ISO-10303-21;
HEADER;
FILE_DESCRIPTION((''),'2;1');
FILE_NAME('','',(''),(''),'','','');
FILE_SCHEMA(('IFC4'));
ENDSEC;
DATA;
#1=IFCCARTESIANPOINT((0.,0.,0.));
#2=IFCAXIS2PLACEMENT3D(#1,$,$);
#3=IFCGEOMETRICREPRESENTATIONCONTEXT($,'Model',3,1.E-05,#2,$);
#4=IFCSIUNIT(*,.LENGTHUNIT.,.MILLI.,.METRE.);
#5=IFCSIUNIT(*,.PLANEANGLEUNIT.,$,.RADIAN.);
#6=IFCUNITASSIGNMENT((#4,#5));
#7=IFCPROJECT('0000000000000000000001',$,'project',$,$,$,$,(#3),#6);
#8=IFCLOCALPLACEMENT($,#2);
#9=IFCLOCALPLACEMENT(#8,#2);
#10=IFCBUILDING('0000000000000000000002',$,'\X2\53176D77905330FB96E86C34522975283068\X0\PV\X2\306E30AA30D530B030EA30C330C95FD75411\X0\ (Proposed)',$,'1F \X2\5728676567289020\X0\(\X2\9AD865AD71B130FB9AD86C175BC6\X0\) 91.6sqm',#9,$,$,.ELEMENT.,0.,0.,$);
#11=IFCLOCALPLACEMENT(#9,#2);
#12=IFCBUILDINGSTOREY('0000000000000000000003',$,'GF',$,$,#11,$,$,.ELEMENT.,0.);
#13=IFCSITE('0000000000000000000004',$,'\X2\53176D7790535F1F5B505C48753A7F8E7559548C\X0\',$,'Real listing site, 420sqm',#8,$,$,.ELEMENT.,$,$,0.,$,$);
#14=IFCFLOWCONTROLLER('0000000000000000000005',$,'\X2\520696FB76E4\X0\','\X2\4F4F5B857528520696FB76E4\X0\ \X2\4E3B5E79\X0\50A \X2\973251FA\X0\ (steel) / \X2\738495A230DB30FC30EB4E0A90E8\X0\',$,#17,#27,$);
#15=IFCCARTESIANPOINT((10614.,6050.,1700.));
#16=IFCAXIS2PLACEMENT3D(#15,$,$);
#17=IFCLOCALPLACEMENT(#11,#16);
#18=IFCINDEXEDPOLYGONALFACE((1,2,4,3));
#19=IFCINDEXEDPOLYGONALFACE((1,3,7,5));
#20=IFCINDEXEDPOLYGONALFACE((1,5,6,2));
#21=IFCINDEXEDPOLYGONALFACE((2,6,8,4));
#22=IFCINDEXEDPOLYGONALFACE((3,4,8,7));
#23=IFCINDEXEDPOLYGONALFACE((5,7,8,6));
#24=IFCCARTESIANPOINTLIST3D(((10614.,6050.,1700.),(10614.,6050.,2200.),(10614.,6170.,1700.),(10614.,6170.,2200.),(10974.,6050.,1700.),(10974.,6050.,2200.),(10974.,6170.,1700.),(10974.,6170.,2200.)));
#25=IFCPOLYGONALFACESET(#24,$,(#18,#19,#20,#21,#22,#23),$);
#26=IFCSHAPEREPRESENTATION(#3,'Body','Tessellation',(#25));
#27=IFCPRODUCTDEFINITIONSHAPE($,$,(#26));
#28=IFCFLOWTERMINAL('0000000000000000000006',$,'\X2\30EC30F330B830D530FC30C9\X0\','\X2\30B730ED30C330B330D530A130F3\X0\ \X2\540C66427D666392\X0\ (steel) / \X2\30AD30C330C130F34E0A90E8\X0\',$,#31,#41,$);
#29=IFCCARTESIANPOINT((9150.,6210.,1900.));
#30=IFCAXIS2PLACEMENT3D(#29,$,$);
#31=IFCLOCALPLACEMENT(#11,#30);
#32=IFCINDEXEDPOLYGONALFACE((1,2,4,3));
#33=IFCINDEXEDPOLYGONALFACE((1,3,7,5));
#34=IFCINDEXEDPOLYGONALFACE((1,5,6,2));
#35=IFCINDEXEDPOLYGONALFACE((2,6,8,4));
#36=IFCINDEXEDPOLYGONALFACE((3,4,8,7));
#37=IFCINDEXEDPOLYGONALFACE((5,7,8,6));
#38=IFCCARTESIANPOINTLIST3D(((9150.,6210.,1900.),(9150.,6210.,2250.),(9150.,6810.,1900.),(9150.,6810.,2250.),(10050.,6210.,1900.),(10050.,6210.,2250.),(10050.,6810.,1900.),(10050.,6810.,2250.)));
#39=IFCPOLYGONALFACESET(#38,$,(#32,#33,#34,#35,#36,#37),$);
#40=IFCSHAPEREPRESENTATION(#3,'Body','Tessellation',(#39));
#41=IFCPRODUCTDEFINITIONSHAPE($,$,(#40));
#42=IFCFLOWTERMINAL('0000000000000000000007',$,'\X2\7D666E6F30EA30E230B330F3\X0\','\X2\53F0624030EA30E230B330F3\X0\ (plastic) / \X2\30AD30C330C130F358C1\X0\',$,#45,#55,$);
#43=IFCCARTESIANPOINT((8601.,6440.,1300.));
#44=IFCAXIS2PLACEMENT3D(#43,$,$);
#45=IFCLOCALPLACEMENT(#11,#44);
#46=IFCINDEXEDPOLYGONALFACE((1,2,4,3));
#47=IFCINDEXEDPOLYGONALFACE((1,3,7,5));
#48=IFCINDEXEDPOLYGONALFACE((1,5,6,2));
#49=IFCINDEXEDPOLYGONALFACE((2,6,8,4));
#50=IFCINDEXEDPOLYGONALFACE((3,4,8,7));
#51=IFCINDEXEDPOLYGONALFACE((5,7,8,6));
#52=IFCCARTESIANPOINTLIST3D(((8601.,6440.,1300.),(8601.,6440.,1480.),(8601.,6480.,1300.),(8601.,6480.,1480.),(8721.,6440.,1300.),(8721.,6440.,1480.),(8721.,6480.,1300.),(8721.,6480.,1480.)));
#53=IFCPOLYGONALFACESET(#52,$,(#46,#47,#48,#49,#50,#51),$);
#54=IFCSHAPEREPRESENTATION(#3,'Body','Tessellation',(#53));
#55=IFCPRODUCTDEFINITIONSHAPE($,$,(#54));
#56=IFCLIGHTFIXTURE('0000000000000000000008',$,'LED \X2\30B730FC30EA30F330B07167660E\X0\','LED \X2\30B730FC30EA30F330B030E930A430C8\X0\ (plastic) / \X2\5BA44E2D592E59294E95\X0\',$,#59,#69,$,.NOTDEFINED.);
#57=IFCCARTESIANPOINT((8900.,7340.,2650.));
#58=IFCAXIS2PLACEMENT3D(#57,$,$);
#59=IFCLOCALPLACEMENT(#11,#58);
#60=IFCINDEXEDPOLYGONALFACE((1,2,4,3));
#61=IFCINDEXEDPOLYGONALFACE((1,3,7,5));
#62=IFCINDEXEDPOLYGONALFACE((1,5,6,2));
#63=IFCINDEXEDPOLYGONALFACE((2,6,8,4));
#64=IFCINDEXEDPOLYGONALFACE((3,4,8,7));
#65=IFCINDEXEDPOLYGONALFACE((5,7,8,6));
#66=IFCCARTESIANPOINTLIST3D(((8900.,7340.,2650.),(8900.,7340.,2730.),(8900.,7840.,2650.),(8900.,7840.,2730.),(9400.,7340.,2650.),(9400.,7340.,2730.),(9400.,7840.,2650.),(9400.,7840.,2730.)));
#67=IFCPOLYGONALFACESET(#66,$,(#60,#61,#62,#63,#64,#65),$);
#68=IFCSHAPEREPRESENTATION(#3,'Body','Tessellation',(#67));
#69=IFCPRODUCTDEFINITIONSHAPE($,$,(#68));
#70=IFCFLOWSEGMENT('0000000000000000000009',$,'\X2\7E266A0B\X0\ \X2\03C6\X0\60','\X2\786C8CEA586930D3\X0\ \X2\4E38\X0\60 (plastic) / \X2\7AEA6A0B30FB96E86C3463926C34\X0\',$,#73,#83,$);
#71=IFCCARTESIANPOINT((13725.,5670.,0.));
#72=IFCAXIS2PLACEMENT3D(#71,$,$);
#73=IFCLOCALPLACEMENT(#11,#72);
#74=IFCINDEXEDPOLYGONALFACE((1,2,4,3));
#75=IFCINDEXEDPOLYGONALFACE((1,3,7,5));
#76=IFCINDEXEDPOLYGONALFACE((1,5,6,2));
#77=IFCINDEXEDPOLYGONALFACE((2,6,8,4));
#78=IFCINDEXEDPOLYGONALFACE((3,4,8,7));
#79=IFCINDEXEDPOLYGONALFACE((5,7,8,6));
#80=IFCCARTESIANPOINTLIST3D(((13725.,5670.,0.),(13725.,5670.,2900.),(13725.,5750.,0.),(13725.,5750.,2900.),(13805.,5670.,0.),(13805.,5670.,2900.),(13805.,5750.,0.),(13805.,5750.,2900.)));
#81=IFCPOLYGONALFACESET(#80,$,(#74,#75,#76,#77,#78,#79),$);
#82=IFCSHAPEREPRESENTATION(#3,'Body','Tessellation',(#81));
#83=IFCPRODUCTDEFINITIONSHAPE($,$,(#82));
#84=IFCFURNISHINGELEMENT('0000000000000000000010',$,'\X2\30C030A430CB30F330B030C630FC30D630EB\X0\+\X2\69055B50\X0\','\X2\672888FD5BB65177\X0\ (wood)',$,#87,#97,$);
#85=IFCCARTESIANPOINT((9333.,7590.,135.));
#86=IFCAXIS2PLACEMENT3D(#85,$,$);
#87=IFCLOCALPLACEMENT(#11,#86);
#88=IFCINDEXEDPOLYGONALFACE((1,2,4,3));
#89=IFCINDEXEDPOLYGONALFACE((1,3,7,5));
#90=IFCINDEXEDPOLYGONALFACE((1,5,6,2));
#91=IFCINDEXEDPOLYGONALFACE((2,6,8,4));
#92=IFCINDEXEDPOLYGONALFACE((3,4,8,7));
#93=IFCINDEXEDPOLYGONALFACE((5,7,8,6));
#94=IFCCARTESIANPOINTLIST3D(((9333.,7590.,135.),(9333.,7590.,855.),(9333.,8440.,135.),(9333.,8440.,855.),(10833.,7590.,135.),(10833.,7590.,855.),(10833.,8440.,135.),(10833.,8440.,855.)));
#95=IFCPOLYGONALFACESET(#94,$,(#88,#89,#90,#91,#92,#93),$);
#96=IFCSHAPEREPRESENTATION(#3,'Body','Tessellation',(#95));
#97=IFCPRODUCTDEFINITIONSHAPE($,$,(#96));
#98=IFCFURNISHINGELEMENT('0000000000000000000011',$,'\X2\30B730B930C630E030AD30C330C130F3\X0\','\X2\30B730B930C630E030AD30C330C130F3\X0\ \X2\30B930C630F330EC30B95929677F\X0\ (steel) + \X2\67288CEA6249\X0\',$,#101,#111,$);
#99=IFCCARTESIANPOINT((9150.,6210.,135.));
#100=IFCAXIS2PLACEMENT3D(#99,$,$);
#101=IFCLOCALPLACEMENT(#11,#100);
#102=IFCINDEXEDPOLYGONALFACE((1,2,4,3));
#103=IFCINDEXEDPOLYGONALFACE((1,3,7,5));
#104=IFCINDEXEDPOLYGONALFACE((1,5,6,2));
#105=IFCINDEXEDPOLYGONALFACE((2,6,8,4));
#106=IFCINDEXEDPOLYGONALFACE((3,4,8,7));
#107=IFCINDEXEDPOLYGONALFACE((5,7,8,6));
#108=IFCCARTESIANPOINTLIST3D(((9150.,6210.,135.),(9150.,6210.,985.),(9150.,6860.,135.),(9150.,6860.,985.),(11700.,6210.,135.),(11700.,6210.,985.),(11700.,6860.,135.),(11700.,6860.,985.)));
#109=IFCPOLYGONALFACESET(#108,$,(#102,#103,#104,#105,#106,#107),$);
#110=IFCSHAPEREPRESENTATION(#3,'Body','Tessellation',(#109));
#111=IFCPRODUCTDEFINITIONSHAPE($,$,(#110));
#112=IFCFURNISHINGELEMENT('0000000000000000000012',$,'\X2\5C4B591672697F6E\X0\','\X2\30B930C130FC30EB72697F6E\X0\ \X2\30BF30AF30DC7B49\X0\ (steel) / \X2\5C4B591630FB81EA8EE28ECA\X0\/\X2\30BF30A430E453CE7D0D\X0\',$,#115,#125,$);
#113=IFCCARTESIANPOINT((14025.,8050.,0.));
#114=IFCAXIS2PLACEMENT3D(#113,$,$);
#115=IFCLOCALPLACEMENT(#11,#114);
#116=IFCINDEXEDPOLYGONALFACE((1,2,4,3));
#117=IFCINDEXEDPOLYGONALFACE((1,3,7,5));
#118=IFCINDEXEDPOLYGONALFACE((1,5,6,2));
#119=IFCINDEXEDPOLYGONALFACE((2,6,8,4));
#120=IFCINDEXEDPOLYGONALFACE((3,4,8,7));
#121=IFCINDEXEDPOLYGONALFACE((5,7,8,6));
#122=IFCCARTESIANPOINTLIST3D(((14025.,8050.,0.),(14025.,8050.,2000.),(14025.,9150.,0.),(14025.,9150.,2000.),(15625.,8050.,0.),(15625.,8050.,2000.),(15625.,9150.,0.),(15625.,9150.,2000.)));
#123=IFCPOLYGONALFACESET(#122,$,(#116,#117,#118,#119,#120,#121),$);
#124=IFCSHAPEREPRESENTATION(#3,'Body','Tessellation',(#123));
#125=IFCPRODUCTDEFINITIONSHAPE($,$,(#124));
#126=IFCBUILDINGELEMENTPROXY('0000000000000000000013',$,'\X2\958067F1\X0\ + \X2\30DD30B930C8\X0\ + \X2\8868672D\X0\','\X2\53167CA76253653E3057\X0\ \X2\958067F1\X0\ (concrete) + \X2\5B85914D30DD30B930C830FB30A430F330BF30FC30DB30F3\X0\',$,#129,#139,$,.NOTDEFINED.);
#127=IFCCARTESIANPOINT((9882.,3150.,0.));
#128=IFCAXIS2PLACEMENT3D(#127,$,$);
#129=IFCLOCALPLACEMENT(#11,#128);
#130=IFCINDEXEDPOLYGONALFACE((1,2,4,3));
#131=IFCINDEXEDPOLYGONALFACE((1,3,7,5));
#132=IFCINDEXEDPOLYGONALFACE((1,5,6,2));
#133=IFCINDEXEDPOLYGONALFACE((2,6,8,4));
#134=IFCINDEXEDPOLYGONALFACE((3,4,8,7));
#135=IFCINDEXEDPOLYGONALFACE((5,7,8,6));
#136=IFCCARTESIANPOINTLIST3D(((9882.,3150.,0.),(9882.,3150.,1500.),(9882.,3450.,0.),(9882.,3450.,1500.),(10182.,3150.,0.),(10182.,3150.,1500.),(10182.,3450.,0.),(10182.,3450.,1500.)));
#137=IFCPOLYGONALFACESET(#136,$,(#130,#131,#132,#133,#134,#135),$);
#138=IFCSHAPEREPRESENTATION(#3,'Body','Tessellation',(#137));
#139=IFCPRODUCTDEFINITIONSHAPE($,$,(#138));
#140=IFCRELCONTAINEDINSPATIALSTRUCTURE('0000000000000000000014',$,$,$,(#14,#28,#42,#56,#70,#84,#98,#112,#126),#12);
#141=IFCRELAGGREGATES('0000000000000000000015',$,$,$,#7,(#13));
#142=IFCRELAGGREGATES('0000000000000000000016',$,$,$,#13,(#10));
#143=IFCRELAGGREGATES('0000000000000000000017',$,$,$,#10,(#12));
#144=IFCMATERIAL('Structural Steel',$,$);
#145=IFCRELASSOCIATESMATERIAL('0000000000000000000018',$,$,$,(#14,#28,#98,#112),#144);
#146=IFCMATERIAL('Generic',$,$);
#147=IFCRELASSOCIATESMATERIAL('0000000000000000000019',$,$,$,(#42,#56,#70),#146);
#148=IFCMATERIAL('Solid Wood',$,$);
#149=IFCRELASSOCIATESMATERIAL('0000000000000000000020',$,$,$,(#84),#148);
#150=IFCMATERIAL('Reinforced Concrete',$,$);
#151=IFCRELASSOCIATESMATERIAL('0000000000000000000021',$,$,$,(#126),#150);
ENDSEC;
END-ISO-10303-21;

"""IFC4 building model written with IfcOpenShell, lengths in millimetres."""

from ifc_helpers import new_model, si_unit, frame, frame_2d, origin, place, context, project, spatial, rectangle, extrude, material, element, save


model = new_model("IFC4")

# Units and contexts
model_context = context("Model", 3, precision=1e-05, world=origin())
ifc_project = project(units=[si_unit("LENGTHUNIT", "METRE", prefix="MILLI"), si_unit("PLANEANGLEUNIT", "RADIAN")], contexts=[model_context])

# Site, building, storey
site_placement = place(None, origin())
site = spatial("IfcSite", under=ifc_project, at=site_placement, Name="北海道弟子屈町美留和", ObjectType="Real listing site, 420sqm", CompositionType="ELEMENT", RefElevation=0.0)
building_placement = place(site_placement, origin())
building = spatial("IfcBuilding", under=site, at=building_placement, Name="北海道・雨水利用とPVのオフグリッド志向 (Proposed)", ObjectType="1F 在来木造(高断熱・高気密) 91.6sqm", CompositionType="ELEMENT", ElevationOfRefHeight=0.0, ElevationOfTerrain=0.0)
storey_placement = place(building_placement, origin())
storey = spatial("IfcBuildingStorey", under=building, at=storey_placement, Name="GF", CompositionType="ELEMENT", Elevation=0.0)

# Shared definitions
ifc_material_1 = material(Name="Solid Wood")

# Shared definitions
ifc_material_2 = material(Name="Structural Steel")

# Shared definitions
ifc_material_3 = material(Name="Reinforced Concrete")

# Flow controller
flow_controller_placement = place(storey_placement, frame((10614.0, 6050.0, 1700.0)))
element("IfcFlowController", 1, at=flow_controller_placement, inside=storey, material=ifc_material_2, Name="分電盤", Description="住宅用分電盤 主幹50A 露出 (steel) / 玄関ホール上部", context=model_context, shape_type="SweptSolid", body=[
    extrude(rectangle(XDim=360.0, YDim=120.0, at=frame_2d((180.0, 60.0))), frame((10614.0, 6050.0, 1700.0)), (0.0, 0.0, 1.0), 500.0),
])

# Flow terminals
flow_terminal_1_placement = place(storey_placement, frame((9150.0, 6210.0, 1900.0)))
element("IfcFlowTerminal", 2, at=flow_terminal_1_placement, inside=storey, material=ifc_material_2, Name="レンジフード", Description="シロッコファン 同時給排 (steel) / キッチン上部", context=model_context, shape_type="SweptSolid", body=[
    extrude(rectangle(XDim=900.0, YDim=600.0, at=frame_2d((450.0, 300.0))), frame((9150.0, 6210.0, 1900.0)), (0.0, 0.0, 1.0), 350.0),
])
ifc_material_4 = material(Name="Generic")
flow_terminal_2_placement = place(storey_placement, frame((8601.0, 6440.0, 1300.0)))
element("IfcFlowTerminal", 3, at=flow_terminal_2_placement, inside=storey, material=ifc_material_4, Name="給湯リモコン", Description="台所リモコン (plastic) / キッチン壁", context=model_context, shape_type="SweptSolid", body=[
    extrude(rectangle(XDim=120.0, YDim=40.0, at=frame_2d((60.0, 20.0))), frame((8601.0, 6440.0, 1300.0)), (0.0, 0.0, 1.0), 180.0),
])

# Light fixture
light_fixture_placement = place(storey_placement, frame((8900.0, 7340.0, 2650.0)))
element("IfcLightFixture", 4, at=light_fixture_placement, inside=storey, material=ifc_material_4, Name="LED シーリング照明", Description="LED シーリングライト (plastic) / 室中央天井", PredefinedType="NOTDEFINED", context=model_context, shape_type="SweptSolid", body=[
    extrude(rectangle(XDim=500.0, YDim=500.0, at=frame_2d((250.0, 250.0))), frame((8900.0, 7340.0, 2650.0)), (0.0, 0.0, 1.0), 80.0),
])

# Flow segment
flow_segment_placement = place(storey_placement, frame((13725.0, 5670.0, 0.0)))
element("IfcFlowSegment", 5, at=flow_segment_placement, inside=storey, material=ifc_material_4, Name="縦樋 φ60", Description="硬質塩ビ 丸60 (plastic) / 竪樋・雨水排水", context=model_context, shape_type="SweptSolid", body=[
    extrude(rectangle(XDim=80.0, YDim=80.0, at=frame_2d((40.0, 40.0))), frame((13725.0, 5670.0, 0.0)), (0.0, 0.0, 1.0), 2900.0),
])

# Furnishing elements
furnishing_1_placement = place(storey_placement, frame((9333.0, 7590.0, 135.0)))
element("IfcFurnishingElement", 6, at=furnishing_1_placement, inside=storey, material=ifc_material_1, Name="ダイニングテーブル+椅子", Description="木製家具 (wood)", context=model_context, shape_type="SweptSolid", body=[
    extrude(rectangle(XDim=1500.0, YDim=850.0, at=frame_2d((750.0, 425.0))), frame((9333.0, 7590.0, 135.0)), (0.0, 0.0, 1.0), 720.0),
])
furnishing_2_placement = place(storey_placement, frame((9150.0, 6210.0, 135.0)))
element("IfcFurnishingElement", 7, at=furnishing_2_placement, inside=storey, material=ifc_material_2, Name="システムキッチン", Description="システムキッチン ステンレス天板 (steel) + 木質扉", context=model_context, shape_type="SweptSolid", body=[
    extrude(rectangle(XDim=2550.0, YDim=650.0, at=frame_2d((1275.0, 325.0))), frame((9150.0, 6210.0, 135.0)), (0.0, 0.0, 1.0), 850.0),
])
furnishing_3_placement = place(storey_placement, frame((14025.0, 8050.0, 0.0)))
element("IfcFurnishingElement", 8, at=furnishing_3_placement, inside=storey, material=ifc_material_2, Name="屋外物置", Description="スチール物置 タクボ等 (steel) / 屋外・自転車/タイヤ収納", context=model_context, shape_type="SweptSolid", body=[
    extrude(rectangle(XDim=1600.0, YDim=1100.0, at=frame_2d((800.0, 550.0))), frame((14025.0, 8050.0, 0.0)), (0.0, 0.0, 1.0), 2000.0),
])

# Building element proxy
proxy_placement = place(storey_placement, frame((9882.0, 3150.0, 0.0)))
element("IfcBuildingElementProxy", 9, at=proxy_placement, inside=storey, material=ifc_material_3, Name="門柱 + ポスト + 表札", Description="化粧打放し 門柱 (concrete) + 宅配ポスト・インターホン", PredefinedType="NOTDEFINED", context=model_context, shape_type="SweptSolid", body=[
    extrude(rectangle(XDim=300.0, YDim=300.0, at=frame_2d((150.0, 150.0))), frame((9882.0, 3150.0, 0.0)), (0.0, 0.0, 1.0), 1500.0),
])

save(model, "model.ifc")
